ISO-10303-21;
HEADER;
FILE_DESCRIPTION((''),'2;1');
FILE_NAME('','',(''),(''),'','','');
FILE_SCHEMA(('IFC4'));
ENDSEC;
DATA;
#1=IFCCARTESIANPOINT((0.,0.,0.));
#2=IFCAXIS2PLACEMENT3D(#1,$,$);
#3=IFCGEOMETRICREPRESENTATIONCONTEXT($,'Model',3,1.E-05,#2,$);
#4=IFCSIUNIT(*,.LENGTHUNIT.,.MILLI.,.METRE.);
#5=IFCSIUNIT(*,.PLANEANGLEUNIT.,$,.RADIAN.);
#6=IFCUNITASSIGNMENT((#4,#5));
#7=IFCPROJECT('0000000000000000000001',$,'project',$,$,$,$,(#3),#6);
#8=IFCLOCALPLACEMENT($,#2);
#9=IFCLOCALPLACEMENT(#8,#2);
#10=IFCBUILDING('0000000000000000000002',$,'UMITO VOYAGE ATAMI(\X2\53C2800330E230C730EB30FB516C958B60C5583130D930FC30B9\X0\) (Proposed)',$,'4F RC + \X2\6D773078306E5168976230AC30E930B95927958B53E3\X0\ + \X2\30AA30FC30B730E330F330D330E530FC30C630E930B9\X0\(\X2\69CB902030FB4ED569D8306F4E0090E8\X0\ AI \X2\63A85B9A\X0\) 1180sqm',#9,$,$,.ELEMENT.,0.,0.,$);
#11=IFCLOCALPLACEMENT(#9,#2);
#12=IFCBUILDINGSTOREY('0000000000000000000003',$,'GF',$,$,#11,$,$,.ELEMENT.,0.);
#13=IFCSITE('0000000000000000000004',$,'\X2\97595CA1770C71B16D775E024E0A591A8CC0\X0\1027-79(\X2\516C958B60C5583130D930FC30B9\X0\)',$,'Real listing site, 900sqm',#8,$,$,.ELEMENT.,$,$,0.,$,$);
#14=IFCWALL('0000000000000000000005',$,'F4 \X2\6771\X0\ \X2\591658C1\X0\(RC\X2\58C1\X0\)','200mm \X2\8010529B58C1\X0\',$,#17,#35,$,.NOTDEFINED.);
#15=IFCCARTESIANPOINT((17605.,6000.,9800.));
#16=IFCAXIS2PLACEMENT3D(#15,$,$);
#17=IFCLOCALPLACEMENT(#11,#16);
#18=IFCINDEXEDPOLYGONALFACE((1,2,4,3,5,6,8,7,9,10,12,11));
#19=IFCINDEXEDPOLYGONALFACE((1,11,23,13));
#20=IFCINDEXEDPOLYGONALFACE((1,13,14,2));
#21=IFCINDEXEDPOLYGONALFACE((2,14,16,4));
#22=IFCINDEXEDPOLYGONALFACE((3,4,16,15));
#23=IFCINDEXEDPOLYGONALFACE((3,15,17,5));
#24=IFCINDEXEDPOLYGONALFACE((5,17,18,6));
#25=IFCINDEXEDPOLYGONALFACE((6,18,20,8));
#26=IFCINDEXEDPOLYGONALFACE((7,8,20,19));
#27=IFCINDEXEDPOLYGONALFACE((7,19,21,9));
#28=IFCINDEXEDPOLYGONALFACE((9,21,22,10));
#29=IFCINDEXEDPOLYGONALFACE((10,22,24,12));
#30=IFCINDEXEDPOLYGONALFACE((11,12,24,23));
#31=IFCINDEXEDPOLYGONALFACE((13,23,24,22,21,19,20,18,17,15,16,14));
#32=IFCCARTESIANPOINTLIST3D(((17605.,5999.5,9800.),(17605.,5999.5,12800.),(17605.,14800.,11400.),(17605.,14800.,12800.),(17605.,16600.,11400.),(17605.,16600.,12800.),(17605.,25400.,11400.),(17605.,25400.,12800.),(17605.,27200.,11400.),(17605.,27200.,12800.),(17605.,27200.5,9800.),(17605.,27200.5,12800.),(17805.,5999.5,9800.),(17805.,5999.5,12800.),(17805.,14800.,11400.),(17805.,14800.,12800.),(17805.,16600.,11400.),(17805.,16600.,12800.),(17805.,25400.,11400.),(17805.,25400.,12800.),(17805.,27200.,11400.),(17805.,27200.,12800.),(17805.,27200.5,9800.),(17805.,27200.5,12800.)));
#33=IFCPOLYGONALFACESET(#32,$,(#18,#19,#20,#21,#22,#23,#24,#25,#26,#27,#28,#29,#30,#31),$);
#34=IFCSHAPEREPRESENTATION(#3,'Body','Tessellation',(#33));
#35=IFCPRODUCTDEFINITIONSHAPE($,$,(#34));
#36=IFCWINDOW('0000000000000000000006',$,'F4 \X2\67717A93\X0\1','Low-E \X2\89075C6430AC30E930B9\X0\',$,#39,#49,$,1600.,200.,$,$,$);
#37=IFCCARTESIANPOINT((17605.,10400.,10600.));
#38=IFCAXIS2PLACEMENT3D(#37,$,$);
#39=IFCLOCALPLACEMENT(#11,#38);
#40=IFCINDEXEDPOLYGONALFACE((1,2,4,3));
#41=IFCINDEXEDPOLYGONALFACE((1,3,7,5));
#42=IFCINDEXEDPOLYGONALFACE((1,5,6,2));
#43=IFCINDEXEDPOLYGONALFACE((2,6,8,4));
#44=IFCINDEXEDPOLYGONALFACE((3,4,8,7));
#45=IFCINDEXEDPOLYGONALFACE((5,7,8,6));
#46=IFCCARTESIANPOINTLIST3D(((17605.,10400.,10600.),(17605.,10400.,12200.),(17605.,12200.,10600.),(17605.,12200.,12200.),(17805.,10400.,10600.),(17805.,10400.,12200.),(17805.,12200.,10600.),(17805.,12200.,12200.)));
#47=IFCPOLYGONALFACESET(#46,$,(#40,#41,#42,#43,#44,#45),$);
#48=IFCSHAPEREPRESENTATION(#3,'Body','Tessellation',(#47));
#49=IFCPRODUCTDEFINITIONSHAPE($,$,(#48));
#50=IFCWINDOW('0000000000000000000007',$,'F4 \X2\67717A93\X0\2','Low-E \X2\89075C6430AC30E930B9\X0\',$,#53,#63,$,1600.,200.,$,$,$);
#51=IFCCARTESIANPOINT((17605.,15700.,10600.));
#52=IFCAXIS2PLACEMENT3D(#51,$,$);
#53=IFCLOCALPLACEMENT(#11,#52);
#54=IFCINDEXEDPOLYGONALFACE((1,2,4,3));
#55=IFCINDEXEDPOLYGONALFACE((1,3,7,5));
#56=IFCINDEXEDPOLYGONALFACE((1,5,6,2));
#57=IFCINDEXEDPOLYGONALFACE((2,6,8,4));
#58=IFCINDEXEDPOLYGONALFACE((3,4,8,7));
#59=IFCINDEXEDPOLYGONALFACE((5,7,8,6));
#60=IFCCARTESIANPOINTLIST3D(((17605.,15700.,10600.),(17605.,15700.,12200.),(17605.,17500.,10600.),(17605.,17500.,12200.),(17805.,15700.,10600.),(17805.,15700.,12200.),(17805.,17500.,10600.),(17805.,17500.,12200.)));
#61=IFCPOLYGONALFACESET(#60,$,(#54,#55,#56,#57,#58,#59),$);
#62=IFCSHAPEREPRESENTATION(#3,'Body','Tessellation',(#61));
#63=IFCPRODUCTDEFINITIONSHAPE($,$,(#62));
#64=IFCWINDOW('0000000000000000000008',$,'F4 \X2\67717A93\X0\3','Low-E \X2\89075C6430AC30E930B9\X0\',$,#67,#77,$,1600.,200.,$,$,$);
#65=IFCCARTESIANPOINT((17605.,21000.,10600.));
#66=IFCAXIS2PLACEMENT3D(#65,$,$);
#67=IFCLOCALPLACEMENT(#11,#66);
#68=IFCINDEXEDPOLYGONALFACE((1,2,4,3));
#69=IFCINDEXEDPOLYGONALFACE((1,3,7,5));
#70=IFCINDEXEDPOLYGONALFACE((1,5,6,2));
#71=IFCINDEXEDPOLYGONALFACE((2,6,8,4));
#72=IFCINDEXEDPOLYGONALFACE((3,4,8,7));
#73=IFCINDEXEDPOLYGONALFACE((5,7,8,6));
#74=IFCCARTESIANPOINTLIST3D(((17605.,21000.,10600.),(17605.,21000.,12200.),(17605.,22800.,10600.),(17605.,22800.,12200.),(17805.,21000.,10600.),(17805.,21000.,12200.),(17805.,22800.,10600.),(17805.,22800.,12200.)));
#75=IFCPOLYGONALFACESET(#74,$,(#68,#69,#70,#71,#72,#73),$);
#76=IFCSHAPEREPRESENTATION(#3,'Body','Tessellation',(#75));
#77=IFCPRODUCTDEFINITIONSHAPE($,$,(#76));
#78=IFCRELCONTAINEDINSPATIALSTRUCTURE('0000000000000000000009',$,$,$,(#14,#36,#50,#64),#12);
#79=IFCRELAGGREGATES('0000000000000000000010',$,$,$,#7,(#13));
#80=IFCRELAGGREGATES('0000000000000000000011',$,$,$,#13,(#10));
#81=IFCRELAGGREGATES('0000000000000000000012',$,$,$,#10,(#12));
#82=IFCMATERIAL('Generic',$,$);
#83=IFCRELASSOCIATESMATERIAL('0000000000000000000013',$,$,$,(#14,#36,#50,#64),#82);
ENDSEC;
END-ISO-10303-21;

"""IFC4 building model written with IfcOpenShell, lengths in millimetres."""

from ifc_helpers import new_model, si_unit, frame, frame_2d, origin, place, context, project, spatial, rectangle, extrude, material, element, fill, save


model = new_model("IFC4")

# Units and contexts
model_context = context("Model", 3, precision=1e-05, world=origin())
ifc_project = project(units=[si_unit("LENGTHUNIT", "METRE", prefix="MILLI"), si_unit("PLANEANGLEUNIT", "RADIAN")], contexts=[model_context])

# Site, building, storey
site_placement = place(None, origin())
site = spatial("IfcSite", under=ifc_project, at=site_placement, Name="静岡県熱海市上多賀1027-79(公開情報ベース)", ObjectType="Real listing site, 900sqm", CompositionType="ELEMENT", RefElevation=0.0)
building_placement = place(site_placement, origin())
building = spatial("IfcBuilding", under=site, at=building_placement, Name="UMITO VOYAGE ATAMI(参考モデル・公開情報ベース) (Proposed)", ObjectType="4F RC + 海への全面ガラス大開口 + オーシャンビューテラス(構造・仕様は一部 AI 推定) 1180sqm", CompositionType="ELEMENT", ElevationOfRefHeight=0.0, ElevationOfTerrain=0.0)
storey_placement = place(building_placement, origin())
storey = spatial("IfcBuildingStorey", under=building, at=storey_placement, Name="GF", CompositionType="ELEMENT", Elevation=0.0)

# Shared definitions
ifc_material = material(Name="Generic")

# Wall, openings, windows
wall_1_placement = place(storey_placement, frame((17605.0, 6000.0, 9800.0)))
wall_1 = element("IfcWall", 1, at=wall_1_placement, inside=storey, material=ifc_material, Name="F4 東 外壁(RC壁)", Description="200mm 耐力壁", PredefinedType="NOTDEFINED", context=model_context, shape_type="SweptSolid", body=[
    extrude(rectangle(XDim=200.0, YDim=21201.0, at=frame_2d((100.0, 10600.0))), frame((17605.0, 6000.0, 9800.0)), (0.0, 0.0, 1.0), 3000.0),
])
opening_1_placement = place(storey_placement, frame((17605.0, 10400.0, 10600.0)))
opening_1 = element("IfcOpeningElement", 2, at=opening_1_placement, cuts=wall_1, PredefinedType="NOTDEFINED", context=model_context, shape_type="SweptSolid", body=[
    extrude(rectangle(XDim=200.0, YDim=1800.0, at=frame_2d((100.0, 900.0))), frame((17605.0, 10400.0, 10600.0)), (0.0, 0.0, 1.0), 1600.0),
])
opening_2_placement = place(storey_placement, frame((17605.0, 15700.0, 10600.0)))
opening_2 = element("IfcOpeningElement", 3, at=opening_2_placement, cuts=wall_1, PredefinedType="NOTDEFINED", context=model_context, shape_type="SweptSolid", body=[
    extrude(rectangle(XDim=200.0, YDim=1800.0, at=frame_2d((100.0, 900.0))), frame((17605.0, 15700.0, 10600.0)), (0.0, 0.0, 1.0), 1600.0),
])
opening_3_placement = place(storey_placement, frame((17605.0, 21000.0, 10600.0)))
opening_3 = element("IfcOpeningElement", 4, at=opening_3_placement, cuts=wall_1, PredefinedType="NOTDEFINED", context=model_context, shape_type="SweptSolid", body=[
    extrude(rectangle(XDim=200.0, YDim=1800.0, at=frame_2d((100.0, 900.0))), frame((17605.0, 21000.0, 10600.0)), (0.0, 0.0, 1.0), 1600.0),
])
window_1_placement = place(storey_placement, frame((17605.0, 10400.0, 10600.0)))
window_1 = element("IfcWindow", 5, at=window_1_placement, inside=storey, material=ifc_material, Name="F4 東窓1", Description="Low-E 複層ガラス", OverallHeight=1600.0, OverallWidth=200.0, context=model_context, shape_type="SweptSolid", body=[
    extrude(rectangle(XDim=200.0, YDim=1800.0, at=frame_2d((100.0, 900.0))), frame((17605.0, 10400.0, 10600.0)), (0.0, 0.0, 1.0), 1600.0),
])
fill(opening_1, window_1)
window_2_placement = place(storey_placement, frame((17605.0, 15700.0, 10600.0)))
window_2 = element("IfcWindow", 6, at=window_2_placement, inside=storey, material=ifc_material, Name="F4 東窓2", Description="Low-E 複層ガラス", OverallHeight=1600.0, OverallWidth=200.0, context=model_context, shape_type="SweptSolid", body=[
    extrude(rectangle(XDim=200.0, YDim=1800.0, at=frame_2d((100.0, 900.0))), frame((17605.0, 15700.0, 10600.0)), (0.0, 0.0, 1.0), 1600.0),
])
fill(opening_2, window_2)
window_3_placement = place(storey_placement, frame((17605.0, 21000.0, 10600.0)))
window_3 = element("IfcWindow", 7, at=window_3_placement, inside=storey, material=ifc_material, Name="F4 東窓3", Description="Low-E 複層ガラス", OverallHeight=1600.0, OverallWidth=200.0, context=model_context, shape_type="SweptSolid", body=[
    extrude(rectangle(XDim=200.0, YDim=1800.0, at=frame_2d((100.0, 900.0))), frame((17605.0, 21000.0, 10600.0)), (0.0, 0.0, 1.0), 1600.0),
])
fill(opening_3, window_3)

save(model, "model.ifc")
